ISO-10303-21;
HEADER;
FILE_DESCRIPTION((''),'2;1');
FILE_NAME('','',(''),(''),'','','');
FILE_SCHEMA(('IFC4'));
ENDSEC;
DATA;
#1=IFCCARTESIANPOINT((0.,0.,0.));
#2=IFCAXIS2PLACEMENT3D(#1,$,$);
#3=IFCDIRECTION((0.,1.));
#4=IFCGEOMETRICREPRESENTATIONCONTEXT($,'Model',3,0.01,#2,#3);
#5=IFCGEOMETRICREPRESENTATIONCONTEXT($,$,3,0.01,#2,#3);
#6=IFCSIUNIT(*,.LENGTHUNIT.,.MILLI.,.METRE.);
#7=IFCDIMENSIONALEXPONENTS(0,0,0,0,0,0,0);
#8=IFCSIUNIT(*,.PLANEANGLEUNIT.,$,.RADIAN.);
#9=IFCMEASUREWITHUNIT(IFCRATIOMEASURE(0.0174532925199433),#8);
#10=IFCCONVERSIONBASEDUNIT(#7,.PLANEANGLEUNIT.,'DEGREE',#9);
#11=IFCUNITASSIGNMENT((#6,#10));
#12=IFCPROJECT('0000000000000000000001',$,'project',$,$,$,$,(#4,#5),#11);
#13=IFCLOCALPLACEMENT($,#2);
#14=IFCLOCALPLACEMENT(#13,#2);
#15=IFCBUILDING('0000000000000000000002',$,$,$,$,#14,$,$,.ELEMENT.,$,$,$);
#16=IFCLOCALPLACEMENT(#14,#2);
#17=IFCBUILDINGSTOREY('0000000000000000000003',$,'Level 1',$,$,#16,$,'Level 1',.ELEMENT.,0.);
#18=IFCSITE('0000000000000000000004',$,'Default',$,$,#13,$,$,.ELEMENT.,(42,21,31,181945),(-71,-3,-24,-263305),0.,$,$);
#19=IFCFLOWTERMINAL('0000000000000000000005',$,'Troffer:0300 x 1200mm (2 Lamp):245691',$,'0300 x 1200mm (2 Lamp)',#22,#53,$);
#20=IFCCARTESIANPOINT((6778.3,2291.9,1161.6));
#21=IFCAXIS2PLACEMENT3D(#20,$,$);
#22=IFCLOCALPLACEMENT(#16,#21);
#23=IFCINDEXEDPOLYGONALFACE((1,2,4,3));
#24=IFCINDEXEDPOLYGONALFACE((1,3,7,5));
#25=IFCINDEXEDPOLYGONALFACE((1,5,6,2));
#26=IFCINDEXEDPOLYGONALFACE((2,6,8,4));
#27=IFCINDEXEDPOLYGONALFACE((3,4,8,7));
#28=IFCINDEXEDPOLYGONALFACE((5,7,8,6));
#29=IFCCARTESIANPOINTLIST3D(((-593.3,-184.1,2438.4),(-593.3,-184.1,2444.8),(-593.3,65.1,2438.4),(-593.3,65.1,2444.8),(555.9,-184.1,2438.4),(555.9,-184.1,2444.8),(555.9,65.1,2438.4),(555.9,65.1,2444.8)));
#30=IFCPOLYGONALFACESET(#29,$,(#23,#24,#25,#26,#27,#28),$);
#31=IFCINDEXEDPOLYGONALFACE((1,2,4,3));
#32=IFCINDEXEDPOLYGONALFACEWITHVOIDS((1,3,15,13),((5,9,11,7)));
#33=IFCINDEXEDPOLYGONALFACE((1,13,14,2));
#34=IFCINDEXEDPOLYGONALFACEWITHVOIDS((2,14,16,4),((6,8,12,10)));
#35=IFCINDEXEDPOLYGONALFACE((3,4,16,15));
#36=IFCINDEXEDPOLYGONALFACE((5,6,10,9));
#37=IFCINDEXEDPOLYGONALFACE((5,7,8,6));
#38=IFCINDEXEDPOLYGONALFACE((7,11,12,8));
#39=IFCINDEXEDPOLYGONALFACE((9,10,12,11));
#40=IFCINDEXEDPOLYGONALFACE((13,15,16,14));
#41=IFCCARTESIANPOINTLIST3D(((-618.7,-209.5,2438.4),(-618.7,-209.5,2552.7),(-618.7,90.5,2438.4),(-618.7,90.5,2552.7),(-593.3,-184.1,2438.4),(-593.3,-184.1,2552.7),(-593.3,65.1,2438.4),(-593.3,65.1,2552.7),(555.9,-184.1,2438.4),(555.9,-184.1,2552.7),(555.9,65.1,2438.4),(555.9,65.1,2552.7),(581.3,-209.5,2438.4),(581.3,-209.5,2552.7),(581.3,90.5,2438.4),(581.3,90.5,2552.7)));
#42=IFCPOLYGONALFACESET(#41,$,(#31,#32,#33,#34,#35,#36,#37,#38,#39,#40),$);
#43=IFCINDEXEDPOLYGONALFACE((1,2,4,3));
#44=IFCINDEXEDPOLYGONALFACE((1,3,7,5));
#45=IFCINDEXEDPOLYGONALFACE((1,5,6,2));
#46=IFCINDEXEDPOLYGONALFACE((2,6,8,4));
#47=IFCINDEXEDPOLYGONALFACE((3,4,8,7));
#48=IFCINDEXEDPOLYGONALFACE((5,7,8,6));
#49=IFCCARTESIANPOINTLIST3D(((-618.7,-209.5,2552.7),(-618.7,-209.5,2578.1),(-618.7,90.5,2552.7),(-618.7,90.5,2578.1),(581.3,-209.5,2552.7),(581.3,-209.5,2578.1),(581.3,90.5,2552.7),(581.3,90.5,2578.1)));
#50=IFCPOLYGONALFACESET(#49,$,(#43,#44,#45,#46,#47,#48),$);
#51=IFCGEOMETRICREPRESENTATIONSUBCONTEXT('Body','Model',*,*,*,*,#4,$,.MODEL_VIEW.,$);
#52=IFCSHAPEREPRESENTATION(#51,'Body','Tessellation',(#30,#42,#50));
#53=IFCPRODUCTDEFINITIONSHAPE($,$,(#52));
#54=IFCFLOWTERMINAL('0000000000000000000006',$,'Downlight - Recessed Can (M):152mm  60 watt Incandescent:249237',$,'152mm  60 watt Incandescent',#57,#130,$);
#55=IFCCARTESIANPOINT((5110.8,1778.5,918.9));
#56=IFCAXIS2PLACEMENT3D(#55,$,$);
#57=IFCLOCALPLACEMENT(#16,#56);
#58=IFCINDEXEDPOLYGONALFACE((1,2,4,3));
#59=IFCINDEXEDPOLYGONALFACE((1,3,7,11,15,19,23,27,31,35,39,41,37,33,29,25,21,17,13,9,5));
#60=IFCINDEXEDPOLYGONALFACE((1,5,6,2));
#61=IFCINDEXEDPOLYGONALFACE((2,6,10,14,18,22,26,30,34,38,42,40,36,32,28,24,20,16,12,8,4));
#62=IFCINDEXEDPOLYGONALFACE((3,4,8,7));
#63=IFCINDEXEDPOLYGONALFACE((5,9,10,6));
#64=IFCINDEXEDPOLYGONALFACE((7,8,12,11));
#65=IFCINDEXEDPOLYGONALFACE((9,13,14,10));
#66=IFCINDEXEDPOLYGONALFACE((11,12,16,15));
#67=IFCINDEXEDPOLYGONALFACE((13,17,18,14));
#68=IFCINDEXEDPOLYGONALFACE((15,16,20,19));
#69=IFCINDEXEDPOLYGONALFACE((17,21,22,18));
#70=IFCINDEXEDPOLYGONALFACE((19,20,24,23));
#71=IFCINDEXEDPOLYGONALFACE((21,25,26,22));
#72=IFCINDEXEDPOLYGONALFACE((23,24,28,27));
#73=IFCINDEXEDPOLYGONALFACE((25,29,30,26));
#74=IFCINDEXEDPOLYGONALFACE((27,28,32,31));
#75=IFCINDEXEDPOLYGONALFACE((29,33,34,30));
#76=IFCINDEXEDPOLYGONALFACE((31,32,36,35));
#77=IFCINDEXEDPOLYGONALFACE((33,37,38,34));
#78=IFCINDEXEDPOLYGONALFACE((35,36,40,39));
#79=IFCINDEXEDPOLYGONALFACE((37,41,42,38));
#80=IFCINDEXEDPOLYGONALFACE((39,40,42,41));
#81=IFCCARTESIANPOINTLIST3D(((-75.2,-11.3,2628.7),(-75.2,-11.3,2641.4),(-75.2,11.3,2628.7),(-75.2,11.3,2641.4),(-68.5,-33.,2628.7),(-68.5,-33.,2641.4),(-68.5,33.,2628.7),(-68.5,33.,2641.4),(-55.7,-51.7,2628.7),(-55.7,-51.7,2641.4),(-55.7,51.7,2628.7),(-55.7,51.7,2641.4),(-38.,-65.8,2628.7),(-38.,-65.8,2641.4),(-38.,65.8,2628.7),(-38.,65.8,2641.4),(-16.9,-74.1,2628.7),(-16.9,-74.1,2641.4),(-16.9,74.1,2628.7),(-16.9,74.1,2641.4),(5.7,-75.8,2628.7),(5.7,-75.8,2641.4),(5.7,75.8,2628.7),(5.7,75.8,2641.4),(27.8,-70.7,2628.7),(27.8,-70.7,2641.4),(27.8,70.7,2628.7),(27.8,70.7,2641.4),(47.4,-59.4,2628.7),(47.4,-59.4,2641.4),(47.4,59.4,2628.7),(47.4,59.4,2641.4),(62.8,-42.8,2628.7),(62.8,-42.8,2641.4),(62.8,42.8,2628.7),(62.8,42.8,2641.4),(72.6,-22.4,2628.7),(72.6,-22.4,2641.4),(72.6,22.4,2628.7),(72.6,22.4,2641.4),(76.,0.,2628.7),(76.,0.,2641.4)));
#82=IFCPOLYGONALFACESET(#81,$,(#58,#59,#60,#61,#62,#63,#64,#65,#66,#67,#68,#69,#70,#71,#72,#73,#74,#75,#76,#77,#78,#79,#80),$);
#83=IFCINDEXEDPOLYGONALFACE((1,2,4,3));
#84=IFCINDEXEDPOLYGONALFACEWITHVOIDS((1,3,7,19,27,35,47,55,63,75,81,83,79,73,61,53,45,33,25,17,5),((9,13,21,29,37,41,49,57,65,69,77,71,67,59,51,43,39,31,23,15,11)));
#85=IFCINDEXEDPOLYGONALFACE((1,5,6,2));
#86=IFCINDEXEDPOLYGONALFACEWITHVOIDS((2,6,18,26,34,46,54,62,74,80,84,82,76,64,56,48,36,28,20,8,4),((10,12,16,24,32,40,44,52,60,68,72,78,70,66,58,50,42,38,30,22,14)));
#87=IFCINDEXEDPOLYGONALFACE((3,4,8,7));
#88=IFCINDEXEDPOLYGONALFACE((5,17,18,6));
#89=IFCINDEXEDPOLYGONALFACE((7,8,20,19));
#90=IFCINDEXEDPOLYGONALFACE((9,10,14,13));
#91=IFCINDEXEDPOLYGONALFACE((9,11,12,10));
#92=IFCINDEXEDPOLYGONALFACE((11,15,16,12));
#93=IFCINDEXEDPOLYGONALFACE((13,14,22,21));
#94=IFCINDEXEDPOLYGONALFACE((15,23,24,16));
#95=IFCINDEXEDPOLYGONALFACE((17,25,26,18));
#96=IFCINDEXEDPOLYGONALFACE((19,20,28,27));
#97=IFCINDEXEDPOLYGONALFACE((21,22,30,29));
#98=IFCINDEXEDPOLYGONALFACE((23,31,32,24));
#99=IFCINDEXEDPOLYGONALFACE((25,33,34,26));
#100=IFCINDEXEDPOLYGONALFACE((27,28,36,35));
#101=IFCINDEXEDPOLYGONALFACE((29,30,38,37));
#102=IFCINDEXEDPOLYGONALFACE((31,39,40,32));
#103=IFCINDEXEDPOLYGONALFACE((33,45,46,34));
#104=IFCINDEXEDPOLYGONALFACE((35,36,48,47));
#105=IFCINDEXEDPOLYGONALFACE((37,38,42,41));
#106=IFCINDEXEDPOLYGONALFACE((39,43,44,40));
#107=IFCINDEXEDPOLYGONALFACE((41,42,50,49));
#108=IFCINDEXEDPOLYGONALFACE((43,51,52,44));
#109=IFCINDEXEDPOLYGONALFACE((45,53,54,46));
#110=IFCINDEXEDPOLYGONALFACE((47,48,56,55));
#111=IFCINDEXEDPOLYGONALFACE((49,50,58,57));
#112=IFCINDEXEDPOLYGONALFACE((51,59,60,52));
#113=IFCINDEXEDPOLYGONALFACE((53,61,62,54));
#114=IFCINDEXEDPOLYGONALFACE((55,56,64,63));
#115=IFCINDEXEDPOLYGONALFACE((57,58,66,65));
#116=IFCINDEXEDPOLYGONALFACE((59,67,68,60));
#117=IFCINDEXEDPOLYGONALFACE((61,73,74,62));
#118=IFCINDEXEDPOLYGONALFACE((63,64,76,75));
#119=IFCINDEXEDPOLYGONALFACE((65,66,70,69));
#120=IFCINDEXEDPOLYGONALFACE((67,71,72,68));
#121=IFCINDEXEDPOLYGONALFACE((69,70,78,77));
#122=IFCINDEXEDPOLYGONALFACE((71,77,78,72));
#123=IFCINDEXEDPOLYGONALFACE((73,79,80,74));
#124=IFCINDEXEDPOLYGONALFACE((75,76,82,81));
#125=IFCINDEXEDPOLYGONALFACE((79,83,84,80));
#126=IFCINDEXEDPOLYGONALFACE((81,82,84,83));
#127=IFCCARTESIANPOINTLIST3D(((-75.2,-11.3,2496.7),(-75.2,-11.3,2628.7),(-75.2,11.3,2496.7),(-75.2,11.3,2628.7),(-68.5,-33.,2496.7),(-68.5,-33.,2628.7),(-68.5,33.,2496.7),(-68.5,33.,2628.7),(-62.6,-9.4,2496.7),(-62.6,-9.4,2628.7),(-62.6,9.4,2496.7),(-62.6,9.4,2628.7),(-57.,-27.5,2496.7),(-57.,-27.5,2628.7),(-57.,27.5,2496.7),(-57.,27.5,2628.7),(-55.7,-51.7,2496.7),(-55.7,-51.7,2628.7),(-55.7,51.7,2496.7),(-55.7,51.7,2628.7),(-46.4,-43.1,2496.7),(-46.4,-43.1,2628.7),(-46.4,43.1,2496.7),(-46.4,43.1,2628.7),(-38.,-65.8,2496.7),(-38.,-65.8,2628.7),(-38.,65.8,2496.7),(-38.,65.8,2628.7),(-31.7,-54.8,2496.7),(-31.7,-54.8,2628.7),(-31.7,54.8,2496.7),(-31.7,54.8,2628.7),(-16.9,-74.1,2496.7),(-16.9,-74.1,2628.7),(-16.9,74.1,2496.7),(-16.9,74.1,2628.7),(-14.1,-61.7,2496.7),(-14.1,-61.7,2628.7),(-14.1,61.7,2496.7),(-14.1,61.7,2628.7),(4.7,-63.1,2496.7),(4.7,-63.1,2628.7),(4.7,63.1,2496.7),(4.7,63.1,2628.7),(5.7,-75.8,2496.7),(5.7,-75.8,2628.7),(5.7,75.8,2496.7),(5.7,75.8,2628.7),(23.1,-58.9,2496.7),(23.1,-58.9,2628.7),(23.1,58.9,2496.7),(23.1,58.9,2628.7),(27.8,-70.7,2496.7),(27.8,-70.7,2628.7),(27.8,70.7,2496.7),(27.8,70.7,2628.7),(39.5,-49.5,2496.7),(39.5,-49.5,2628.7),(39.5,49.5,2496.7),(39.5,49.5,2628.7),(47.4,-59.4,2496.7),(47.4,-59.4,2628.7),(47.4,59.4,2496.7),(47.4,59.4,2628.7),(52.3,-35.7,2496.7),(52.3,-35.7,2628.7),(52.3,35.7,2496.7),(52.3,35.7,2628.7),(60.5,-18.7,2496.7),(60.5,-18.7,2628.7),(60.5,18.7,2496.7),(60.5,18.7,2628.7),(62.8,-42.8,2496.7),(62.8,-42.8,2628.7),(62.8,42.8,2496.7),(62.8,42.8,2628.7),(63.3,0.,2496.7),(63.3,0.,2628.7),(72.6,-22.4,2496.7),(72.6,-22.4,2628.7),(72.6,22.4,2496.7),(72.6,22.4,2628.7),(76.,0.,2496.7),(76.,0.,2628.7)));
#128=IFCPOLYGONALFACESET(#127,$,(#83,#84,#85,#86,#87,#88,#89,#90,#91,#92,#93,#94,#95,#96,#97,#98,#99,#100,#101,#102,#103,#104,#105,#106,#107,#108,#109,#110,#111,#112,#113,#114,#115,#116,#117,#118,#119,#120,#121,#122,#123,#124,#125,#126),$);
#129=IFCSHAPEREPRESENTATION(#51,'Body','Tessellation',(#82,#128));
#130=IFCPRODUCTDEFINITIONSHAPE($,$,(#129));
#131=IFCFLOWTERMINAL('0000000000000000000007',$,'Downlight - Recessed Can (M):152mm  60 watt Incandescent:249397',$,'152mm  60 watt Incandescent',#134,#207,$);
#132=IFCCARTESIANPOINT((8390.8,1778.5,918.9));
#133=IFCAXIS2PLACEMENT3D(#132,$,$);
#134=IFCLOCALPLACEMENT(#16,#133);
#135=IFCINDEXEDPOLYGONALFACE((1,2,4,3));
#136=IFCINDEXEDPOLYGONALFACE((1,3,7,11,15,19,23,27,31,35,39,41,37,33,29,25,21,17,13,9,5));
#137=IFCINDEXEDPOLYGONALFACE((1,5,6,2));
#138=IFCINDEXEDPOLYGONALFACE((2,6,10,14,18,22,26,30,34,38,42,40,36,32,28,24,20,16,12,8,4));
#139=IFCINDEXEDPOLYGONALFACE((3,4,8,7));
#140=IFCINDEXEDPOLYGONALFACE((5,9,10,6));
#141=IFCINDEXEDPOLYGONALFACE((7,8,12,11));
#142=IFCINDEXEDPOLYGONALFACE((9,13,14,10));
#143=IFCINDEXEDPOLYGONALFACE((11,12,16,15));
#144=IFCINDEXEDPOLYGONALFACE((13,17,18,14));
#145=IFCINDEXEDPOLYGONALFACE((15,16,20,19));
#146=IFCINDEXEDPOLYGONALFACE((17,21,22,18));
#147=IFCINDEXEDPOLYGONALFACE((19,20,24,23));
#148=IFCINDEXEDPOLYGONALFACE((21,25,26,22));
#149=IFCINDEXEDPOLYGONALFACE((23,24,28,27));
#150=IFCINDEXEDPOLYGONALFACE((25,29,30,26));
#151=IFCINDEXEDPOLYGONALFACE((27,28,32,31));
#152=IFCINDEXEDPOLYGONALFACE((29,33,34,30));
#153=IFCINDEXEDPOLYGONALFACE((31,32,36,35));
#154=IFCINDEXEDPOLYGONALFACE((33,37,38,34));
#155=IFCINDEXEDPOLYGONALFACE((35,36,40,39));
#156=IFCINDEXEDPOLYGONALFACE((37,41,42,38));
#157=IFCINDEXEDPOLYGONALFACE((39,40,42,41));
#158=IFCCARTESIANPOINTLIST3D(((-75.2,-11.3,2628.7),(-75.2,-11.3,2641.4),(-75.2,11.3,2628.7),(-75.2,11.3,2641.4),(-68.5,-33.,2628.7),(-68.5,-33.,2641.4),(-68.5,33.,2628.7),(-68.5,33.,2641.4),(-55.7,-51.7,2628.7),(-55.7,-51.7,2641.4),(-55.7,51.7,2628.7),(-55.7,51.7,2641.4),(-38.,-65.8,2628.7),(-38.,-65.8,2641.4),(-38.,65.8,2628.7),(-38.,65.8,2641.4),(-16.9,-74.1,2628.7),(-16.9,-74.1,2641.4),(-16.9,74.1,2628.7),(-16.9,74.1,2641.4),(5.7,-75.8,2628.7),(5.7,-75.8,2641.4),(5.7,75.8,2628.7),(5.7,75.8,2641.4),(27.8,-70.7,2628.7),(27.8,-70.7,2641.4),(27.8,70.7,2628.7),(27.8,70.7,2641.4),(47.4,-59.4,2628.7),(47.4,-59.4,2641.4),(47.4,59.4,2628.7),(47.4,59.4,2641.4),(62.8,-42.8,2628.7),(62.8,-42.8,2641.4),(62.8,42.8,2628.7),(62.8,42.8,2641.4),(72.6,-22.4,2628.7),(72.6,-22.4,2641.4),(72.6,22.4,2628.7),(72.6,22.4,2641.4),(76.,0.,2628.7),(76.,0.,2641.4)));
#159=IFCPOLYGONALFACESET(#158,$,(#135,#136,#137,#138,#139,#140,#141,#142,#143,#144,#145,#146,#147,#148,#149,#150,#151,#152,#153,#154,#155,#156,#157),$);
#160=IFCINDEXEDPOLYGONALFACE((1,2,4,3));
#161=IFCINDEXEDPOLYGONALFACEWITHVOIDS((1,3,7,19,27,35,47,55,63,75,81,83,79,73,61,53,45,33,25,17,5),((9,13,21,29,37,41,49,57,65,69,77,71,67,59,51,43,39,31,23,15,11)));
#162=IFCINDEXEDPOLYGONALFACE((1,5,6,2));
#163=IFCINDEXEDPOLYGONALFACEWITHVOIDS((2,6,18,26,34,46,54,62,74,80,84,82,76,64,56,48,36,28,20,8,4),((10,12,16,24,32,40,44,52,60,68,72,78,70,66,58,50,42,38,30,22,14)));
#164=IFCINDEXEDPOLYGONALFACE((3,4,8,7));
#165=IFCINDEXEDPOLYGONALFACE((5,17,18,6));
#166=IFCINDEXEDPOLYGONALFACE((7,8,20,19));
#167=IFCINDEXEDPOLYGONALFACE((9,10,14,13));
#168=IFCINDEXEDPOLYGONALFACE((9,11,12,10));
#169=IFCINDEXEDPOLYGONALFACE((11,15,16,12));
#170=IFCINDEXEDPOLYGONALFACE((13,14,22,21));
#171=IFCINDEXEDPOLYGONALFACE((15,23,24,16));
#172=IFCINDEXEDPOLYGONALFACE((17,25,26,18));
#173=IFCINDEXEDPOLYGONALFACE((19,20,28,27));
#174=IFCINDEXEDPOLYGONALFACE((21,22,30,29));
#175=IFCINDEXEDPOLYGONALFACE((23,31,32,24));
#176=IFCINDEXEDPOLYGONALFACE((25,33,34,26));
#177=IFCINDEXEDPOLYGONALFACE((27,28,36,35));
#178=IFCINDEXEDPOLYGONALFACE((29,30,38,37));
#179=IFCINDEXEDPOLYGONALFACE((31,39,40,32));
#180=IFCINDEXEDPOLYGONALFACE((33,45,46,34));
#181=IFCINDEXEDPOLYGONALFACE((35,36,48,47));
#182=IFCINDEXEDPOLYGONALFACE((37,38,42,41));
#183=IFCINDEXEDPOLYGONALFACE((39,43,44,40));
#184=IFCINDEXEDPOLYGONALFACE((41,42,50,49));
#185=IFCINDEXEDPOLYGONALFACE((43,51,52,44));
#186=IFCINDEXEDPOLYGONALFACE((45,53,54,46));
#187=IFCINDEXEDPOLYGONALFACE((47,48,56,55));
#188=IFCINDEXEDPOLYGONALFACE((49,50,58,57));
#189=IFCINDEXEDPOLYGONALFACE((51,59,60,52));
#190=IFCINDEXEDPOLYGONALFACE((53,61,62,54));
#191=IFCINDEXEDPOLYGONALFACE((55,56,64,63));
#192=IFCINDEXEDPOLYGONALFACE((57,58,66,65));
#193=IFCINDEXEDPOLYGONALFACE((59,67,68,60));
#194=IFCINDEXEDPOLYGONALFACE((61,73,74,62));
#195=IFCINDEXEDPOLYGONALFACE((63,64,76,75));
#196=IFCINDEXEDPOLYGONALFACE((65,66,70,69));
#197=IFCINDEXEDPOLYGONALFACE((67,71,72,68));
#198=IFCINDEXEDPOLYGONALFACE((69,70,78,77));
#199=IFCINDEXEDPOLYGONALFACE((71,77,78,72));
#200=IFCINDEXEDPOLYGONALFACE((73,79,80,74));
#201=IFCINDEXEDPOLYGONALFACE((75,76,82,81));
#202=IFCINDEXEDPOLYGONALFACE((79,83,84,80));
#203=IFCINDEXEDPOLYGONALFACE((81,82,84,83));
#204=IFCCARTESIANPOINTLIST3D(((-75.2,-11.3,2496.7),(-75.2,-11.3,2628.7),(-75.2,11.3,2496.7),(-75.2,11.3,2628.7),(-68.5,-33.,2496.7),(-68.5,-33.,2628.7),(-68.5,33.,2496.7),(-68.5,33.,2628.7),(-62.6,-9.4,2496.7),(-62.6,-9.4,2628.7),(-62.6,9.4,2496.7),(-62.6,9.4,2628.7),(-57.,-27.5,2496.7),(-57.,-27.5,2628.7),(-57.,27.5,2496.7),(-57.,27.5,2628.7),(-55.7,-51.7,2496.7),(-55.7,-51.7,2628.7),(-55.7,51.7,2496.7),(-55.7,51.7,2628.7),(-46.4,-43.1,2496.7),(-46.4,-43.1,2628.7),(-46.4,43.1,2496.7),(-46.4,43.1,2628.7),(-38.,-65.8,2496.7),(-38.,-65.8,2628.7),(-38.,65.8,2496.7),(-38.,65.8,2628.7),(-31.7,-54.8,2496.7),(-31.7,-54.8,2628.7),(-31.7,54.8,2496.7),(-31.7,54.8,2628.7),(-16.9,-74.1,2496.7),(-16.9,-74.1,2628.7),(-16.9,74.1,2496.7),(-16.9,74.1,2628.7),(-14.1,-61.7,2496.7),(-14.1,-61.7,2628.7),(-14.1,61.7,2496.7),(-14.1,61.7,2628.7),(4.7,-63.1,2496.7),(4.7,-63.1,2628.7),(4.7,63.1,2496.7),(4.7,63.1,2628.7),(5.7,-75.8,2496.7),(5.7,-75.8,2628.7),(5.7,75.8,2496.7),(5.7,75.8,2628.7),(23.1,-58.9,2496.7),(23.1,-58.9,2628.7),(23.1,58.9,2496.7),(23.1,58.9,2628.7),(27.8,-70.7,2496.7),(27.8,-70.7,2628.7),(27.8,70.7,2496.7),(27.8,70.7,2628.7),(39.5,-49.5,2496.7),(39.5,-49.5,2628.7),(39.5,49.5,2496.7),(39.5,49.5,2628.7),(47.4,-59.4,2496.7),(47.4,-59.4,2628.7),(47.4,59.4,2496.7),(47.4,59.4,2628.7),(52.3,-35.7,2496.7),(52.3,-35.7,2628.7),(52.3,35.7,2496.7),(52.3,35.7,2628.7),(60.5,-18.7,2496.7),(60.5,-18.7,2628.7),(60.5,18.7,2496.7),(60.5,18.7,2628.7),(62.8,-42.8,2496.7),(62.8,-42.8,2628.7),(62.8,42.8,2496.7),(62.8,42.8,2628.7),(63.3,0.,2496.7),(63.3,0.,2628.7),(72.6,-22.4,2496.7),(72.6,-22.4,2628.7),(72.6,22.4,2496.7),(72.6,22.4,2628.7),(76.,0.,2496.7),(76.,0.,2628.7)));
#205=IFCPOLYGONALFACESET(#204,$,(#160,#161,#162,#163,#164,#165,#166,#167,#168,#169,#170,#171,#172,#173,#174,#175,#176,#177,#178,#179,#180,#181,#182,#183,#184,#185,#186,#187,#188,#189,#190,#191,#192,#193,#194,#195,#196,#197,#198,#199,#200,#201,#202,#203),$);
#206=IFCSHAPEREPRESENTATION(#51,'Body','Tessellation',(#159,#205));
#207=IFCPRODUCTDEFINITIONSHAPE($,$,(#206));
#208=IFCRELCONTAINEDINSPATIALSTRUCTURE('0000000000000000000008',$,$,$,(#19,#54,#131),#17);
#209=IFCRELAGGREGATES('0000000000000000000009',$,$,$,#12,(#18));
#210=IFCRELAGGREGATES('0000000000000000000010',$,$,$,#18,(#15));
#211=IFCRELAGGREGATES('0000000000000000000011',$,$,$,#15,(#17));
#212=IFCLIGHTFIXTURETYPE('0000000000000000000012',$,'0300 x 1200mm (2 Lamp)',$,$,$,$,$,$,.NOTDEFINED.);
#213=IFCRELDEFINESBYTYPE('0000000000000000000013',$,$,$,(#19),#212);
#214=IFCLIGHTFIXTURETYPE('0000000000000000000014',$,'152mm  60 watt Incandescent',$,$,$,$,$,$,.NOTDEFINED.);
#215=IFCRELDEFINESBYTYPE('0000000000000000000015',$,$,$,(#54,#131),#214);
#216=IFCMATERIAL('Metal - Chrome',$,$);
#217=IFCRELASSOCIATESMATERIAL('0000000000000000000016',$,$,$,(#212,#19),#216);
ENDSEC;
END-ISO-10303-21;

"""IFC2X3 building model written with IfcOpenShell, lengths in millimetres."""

from ifc_helpers import new_model, entity, si_unit, converted_unit, direction, frame, frame_2d, origin, origin_2d_with_axis, place, context, subcontext, project, spatial, polyline, rectangle, circle, hollow_circle, outline, extrude, source, transform, mapped, material, type_object, type_shapes, element, save


model = new_model("IFC2X3")

# Units and contexts
model_context = context("Model", 3, precision=0.01, world=origin(), true_north=direction((0.0, 1.0)))
context_of_model = context(None, 3, precision=0.01, world=origin(), true_north=direction((0.0, 1.0)))
body_context = subcontext(model_context, "Body", "Model", "MODEL_VIEW")
ifc_project = project(units=[si_unit("LENGTHUNIT", "METRE", prefix="MILLI"), converted_unit("PLANEANGLEUNIT", "DEGREE", entity("IfcRatioMeasure", 0.0174532925199433), si_unit("PLANEANGLEUNIT", "RADIAN"), dimensions=[0, 0, 0, 0, 0, 0, 0])], contexts=[model_context, context_of_model])

# Site, building, storey
site_placement = place(None, origin())
site = spatial("IfcSite", under=ifc_project, at=site_placement, Name="Default", CompositionType="ELEMENT", RefLatitude=(42, 21, 31, 181945), RefLongitude=(-71, -3, -24, -263305), RefElevation=0.0)
building_placement = place(site_placement, origin())
building = spatial("IfcBuilding", under=site, at=building_placement, CompositionType="ELEMENT")
storey_placement = place(building_placement, origin())
storey = spatial("IfcBuildingStorey", under=building, at=storey_placement, Name="Level 1", LongName="Level 1", CompositionType="ELEMENT", Elevation=0.0)

# Flow terminals
ifc_material_1 = material(Name="Metal - Chrome")
light_fixture_type_1 = type_object("IfcLightFixtureType", Name="0300 x 1200mm (2 Lamp)", PredefinedType="NOTDEFINED", material=ifc_material_1)
shared_shape_1 = source(origin(), body_context, "Body", "SweptSolid", [
    extrude(rectangle(XDim=1149.2, YDim=249.2, at=origin_2d_with_axis()), frame((-18.7, -59.5, 2438.4), z_axis=(0.0, 0.0, 1.0), x_axis=(-1.0, 0.0, 0.0)), (0.0, 0.0, 1.0), 6.4),
    extrude(outline(polyline([(-600.0, -150.0), (600.0, -150.0), (600.0, 150.0), (-600.0, 150.0), (-600.0, -150.0)]), holes=[polyline([(-574.6, -124.6), (-574.6, 124.6), (574.6, 124.6), (574.6, -124.6), (-574.6, -124.6)])]), frame((-18.7, -59.5, 2438.4), z_axis=(0.0, 0.0, 1.0), x_axis=(-1.0, 0.0, 0.0)), (0.0, 0.0, 1.0), 114.3),
    extrude(rectangle(XDim=1200.0, YDim=300.0, at=frame_2d((0.0, 0.0), x_axis=(1.0, 0.0))), frame((-18.7, -59.5, 2552.7), z_axis=(0.0, 0.0, 1.0), x_axis=(-1.0, 0.0, 0.0)), (0.0, 0.0, 1.0), 25.4),
])
type_shapes(light_fixture_type_1, [shared_shape_1])
flow_terminal_1_placement = place(storey_placement, frame((6778.3, 2291.9, 1161.6)))
element("IfcFlowTerminal", 1, at=flow_terminal_1_placement, inside=storey, type_object=light_fixture_type_1, material=ifc_material_1, Name="Troffer:0300 x 1200mm (2 Lamp):245691", ObjectType="0300 x 1200mm (2 Lamp)", context=body_context, shape_type="MappedRepresentation", body=[
    mapped(shared_shape_1, transform((0.0, 0.0, 0.0), scale=1.0)),
])
light_fixture_type_2 = type_object("IfcLightFixtureType", Name="152mm  60 watt Incandescent", PredefinedType="NOTDEFINED")
shared_shape_2 = source(origin(), body_context, "Body", "SweptSolid", [
    extrude(circle(Radius=76.0, at=frame_2d((0.0, 0.0), x_axis=(1.0, 0.0))), frame((0.0, 0.0, 2628.7)), (0.0, 0.0, 1.0), 12.7),
    extrude(hollow_circle(Radius=76.0, WallThickness=12.7, at=frame_2d((0.0, 0.0), x_axis=(1.0, 0.0))), frame((0.0, 0.0, 2496.7)), (0.0, 0.0, 1.0), 132.0),
])
type_shapes(light_fixture_type_2, [shared_shape_2])
for number, where, name in (
    (2, (5110.8, 1778.5, 918.9), "Downlight - Recessed Can (M):152mm  60 watt Incandescent:249237"),
    (3, (8390.8, 1778.5, 918.9), "Downlight - Recessed Can (M):152mm  60 watt Incandescent:249397"),
):
    element("IfcFlowTerminal", number, at=place(storey_placement, frame(where)), inside=storey, type_object=light_fixture_type_2, Name=name, ObjectType="152mm  60 watt Incandescent", context=body_context, shape_type="MappedRepresentation", body=[
        mapped(shared_shape_2, transform((0.0, 0.0, 0.0), scale=1.0)),
    ])

save(model, "model.ifc")
